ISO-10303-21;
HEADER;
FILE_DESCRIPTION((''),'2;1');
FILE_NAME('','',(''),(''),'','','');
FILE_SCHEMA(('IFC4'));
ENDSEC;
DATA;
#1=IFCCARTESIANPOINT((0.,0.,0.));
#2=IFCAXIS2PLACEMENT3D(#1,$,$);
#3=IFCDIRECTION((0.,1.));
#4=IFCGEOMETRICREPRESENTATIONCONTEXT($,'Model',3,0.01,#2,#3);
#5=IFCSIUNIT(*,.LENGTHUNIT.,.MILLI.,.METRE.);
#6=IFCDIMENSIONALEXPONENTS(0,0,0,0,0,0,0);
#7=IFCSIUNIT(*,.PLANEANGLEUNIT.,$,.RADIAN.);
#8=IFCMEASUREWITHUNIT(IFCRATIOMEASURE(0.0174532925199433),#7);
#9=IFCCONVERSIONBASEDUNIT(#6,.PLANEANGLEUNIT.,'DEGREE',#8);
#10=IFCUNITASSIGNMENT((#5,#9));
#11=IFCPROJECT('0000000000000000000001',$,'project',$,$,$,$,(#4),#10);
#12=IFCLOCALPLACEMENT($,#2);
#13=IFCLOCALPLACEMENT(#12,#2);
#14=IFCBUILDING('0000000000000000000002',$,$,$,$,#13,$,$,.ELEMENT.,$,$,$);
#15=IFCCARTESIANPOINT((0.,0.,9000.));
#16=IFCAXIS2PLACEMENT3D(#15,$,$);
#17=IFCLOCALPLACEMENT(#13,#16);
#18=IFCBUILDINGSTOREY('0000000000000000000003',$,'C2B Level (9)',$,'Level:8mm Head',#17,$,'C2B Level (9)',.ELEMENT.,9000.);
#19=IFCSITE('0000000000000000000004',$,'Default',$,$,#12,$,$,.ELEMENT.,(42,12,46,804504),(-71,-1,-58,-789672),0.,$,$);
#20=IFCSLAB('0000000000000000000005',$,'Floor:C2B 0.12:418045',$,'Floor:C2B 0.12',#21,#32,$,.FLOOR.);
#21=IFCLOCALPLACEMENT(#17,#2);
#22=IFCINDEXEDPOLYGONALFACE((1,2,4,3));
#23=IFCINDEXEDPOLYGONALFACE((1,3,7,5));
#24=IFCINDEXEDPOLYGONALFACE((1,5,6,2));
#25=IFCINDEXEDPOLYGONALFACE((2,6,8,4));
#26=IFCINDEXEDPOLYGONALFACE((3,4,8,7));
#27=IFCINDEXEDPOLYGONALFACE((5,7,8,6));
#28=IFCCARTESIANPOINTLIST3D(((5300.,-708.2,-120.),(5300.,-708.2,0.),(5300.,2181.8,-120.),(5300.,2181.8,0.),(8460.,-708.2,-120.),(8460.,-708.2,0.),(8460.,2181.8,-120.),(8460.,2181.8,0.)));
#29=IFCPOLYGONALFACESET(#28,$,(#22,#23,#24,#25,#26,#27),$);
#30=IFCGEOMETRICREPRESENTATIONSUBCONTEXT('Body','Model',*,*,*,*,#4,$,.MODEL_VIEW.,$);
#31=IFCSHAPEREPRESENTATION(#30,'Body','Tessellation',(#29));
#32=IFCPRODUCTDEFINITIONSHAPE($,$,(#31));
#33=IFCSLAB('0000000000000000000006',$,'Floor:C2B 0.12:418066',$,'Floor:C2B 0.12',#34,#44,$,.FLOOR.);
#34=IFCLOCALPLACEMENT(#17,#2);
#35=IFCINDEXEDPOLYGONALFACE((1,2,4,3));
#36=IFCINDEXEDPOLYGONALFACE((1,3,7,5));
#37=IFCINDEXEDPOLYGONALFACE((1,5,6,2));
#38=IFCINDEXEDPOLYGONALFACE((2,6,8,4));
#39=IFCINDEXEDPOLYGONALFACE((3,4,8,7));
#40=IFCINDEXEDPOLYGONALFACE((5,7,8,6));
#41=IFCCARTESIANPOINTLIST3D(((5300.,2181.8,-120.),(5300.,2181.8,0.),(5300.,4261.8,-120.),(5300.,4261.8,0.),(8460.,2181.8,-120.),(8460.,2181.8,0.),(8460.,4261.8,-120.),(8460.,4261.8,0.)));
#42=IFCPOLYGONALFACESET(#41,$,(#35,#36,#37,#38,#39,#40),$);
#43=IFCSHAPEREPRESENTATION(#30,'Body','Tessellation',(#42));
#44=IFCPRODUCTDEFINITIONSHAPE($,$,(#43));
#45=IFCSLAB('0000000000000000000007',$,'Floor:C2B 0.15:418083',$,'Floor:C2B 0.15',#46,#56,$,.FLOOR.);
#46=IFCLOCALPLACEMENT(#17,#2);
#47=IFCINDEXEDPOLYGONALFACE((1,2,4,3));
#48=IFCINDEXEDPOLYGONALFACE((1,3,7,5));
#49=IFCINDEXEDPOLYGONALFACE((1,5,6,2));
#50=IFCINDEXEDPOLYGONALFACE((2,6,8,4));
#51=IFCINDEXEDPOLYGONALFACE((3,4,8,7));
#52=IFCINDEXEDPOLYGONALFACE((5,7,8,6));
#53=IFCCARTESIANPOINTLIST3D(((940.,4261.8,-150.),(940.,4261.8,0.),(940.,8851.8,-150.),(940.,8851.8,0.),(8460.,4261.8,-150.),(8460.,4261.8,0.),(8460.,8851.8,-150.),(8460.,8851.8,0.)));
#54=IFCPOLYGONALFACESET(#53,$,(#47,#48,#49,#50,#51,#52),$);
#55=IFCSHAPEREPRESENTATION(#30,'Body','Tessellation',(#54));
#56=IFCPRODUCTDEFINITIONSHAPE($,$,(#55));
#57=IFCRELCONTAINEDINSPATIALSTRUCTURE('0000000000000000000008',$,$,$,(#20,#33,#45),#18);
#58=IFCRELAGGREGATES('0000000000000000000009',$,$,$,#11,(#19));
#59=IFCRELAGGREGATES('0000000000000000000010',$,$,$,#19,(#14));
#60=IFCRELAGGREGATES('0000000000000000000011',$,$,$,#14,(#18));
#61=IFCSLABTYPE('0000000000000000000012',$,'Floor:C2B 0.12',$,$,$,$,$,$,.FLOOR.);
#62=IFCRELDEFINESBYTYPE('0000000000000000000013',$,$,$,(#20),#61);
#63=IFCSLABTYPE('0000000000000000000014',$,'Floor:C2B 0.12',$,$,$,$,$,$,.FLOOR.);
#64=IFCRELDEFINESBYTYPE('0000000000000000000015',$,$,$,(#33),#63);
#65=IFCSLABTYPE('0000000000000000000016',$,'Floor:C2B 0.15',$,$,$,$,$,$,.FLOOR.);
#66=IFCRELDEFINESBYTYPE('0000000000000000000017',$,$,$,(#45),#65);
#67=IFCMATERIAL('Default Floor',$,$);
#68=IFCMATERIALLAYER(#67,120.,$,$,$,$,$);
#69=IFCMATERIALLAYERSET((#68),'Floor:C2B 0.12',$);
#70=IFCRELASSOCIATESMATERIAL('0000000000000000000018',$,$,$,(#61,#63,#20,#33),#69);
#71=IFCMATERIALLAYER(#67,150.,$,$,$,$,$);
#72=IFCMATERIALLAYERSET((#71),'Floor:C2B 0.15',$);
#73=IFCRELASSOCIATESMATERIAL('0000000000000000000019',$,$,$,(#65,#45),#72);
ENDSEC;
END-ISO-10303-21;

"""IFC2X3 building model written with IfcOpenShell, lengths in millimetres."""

from ifc_helpers import new_model, entity, si_unit, converted_unit, direction, frame, frame_2d, origin, origin_2d_with_axis, place, context, subcontext, project, spatial, rectangle, extrude, material, layer, layer_set, layer_usage, type_object, element, save


model = new_model("IFC2X3")

# Units and contexts
model_context = context("Model", 3, precision=0.01, world=origin(), true_north=direction((0.0, 1.0)))
body_context = subcontext(model_context, "Body", "Model", "MODEL_VIEW")
ifc_project = project(units=[si_unit("LENGTHUNIT", "METRE", prefix="MILLI"), converted_unit("PLANEANGLEUNIT", "DEGREE", entity("IfcRatioMeasure", 0.0174532925199433), si_unit("PLANEANGLEUNIT", "RADIAN"), dimensions=[0, 0, 0, 0, 0, 0, 0])], contexts=[model_context])

# Site, building, storey
site_placement = place(None, origin())
site = spatial("IfcSite", under=ifc_project, at=site_placement, Name="Default", CompositionType="ELEMENT", RefLatitude=(42, 12, 46, 804504), RefLongitude=(-71, -1, -58, -789672), RefElevation=0.0)
building_placement = place(site_placement, origin())
building = spatial("IfcBuilding", under=site, at=building_placement, CompositionType="ELEMENT")
storey_placement = place(building_placement, frame((0.0, 0.0, 9000.0)))
storey = spatial("IfcBuildingStorey", under=building, at=storey_placement, Name="C2B Level (9)", ObjectType="Level:8mm Head", LongName="C2B Level (9)", CompositionType="ELEMENT", Elevation=9000.0)

# Slabs
ifc_material_1 = material(Name="Default Floor")
ifc_layer_1 = layer(ifc_material_1, 120.0)
ifc_layer_set_1 = layer_set([ifc_layer_1], Name="Floor:C2B 0.12")
ifc_layer_usage_1 = layer_usage(ifc_layer_set_1, "AXIS3", "POSITIVE", 0.0)
slab_type_1 = type_object("IfcSlabType", Name="Floor:C2B 0.12", PredefinedType="FLOOR", material=ifc_layer_set_1)
slab_1_placement = place(storey_placement, origin())
element("IfcSlab", 1, at=slab_1_placement, inside=storey, type_object=slab_type_1, material=ifc_layer_usage_1, Name="Floor:C2B 0.12:418045", ObjectType="Floor:C2B 0.12", PredefinedType="FLOOR", context=body_context, shape_type="SweptSolid", body=[
    extrude(rectangle(XDim=2890.0, YDim=3160.0, at=origin_2d_with_axis()), frame((6880.0, 736.8, 0.0), z_axis=(0.0, 0.0, -1.0), x_axis=(0.0, 1.0, 0.0)), (0.0, 0.0, 1.0), 120.0),
])
ifc_layer_usage_2 = layer_usage(ifc_layer_set_1, "AXIS3", "POSITIVE", 0.0)
slab_type_2 = type_object("IfcSlabType", Name="Floor:C2B 0.12", PredefinedType="FLOOR", material=ifc_layer_set_1)
slab_2_placement = place(storey_placement, origin())
element("IfcSlab", 2, at=slab_2_placement, inside=storey, type_object=slab_type_2, material=ifc_layer_usage_2, Name="Floor:C2B 0.12:418066", ObjectType="Floor:C2B 0.12", PredefinedType="FLOOR", context=body_context, shape_type="SweptSolid", body=[
    extrude(rectangle(XDim=2080.0, YDim=3160.0, at=frame_2d((0.0, 0.0), x_axis=(1.0, 0.0))), frame((6880.0, 3221.8, 0.0), z_axis=(0.0, 0.0, -1.0), x_axis=(0.0, 1.0, 0.0)), (0.0, 0.0, 1.0), 120.0),
])
ifc_layer_2 = layer(ifc_material_1, 150.0)
ifc_layer_set_2 = layer_set([ifc_layer_2], Name="Floor:C2B 0.15")
ifc_layer_usage_3 = layer_usage(ifc_layer_set_2, "AXIS3", "POSITIVE", 0.0)
slab_type_3 = type_object("IfcSlabType", Name="Floor:C2B 0.15", PredefinedType="FLOOR", material=ifc_layer_set_2)
slab_3_placement = place(storey_placement, origin())
element("IfcSlab", 3, at=slab_3_placement, inside=storey, type_object=slab_type_3, material=ifc_layer_usage_3, Name="Floor:C2B 0.15:418083", ObjectType="Floor:C2B 0.15", PredefinedType="FLOOR", context=body_context, shape_type="SweptSolid", body=[
    extrude(rectangle(XDim=4590.0, YDim=7520.0, at=frame_2d((0.0, 0.0), x_axis=(1.0, 0.0))), frame((4700.0, 6556.8, 0.0), z_axis=(0.0, 0.0, -1.0), x_axis=(0.0, 1.0, 0.0)), (0.0, 0.0, 1.0), 150.0),
])

save(model, "model.ifc")
